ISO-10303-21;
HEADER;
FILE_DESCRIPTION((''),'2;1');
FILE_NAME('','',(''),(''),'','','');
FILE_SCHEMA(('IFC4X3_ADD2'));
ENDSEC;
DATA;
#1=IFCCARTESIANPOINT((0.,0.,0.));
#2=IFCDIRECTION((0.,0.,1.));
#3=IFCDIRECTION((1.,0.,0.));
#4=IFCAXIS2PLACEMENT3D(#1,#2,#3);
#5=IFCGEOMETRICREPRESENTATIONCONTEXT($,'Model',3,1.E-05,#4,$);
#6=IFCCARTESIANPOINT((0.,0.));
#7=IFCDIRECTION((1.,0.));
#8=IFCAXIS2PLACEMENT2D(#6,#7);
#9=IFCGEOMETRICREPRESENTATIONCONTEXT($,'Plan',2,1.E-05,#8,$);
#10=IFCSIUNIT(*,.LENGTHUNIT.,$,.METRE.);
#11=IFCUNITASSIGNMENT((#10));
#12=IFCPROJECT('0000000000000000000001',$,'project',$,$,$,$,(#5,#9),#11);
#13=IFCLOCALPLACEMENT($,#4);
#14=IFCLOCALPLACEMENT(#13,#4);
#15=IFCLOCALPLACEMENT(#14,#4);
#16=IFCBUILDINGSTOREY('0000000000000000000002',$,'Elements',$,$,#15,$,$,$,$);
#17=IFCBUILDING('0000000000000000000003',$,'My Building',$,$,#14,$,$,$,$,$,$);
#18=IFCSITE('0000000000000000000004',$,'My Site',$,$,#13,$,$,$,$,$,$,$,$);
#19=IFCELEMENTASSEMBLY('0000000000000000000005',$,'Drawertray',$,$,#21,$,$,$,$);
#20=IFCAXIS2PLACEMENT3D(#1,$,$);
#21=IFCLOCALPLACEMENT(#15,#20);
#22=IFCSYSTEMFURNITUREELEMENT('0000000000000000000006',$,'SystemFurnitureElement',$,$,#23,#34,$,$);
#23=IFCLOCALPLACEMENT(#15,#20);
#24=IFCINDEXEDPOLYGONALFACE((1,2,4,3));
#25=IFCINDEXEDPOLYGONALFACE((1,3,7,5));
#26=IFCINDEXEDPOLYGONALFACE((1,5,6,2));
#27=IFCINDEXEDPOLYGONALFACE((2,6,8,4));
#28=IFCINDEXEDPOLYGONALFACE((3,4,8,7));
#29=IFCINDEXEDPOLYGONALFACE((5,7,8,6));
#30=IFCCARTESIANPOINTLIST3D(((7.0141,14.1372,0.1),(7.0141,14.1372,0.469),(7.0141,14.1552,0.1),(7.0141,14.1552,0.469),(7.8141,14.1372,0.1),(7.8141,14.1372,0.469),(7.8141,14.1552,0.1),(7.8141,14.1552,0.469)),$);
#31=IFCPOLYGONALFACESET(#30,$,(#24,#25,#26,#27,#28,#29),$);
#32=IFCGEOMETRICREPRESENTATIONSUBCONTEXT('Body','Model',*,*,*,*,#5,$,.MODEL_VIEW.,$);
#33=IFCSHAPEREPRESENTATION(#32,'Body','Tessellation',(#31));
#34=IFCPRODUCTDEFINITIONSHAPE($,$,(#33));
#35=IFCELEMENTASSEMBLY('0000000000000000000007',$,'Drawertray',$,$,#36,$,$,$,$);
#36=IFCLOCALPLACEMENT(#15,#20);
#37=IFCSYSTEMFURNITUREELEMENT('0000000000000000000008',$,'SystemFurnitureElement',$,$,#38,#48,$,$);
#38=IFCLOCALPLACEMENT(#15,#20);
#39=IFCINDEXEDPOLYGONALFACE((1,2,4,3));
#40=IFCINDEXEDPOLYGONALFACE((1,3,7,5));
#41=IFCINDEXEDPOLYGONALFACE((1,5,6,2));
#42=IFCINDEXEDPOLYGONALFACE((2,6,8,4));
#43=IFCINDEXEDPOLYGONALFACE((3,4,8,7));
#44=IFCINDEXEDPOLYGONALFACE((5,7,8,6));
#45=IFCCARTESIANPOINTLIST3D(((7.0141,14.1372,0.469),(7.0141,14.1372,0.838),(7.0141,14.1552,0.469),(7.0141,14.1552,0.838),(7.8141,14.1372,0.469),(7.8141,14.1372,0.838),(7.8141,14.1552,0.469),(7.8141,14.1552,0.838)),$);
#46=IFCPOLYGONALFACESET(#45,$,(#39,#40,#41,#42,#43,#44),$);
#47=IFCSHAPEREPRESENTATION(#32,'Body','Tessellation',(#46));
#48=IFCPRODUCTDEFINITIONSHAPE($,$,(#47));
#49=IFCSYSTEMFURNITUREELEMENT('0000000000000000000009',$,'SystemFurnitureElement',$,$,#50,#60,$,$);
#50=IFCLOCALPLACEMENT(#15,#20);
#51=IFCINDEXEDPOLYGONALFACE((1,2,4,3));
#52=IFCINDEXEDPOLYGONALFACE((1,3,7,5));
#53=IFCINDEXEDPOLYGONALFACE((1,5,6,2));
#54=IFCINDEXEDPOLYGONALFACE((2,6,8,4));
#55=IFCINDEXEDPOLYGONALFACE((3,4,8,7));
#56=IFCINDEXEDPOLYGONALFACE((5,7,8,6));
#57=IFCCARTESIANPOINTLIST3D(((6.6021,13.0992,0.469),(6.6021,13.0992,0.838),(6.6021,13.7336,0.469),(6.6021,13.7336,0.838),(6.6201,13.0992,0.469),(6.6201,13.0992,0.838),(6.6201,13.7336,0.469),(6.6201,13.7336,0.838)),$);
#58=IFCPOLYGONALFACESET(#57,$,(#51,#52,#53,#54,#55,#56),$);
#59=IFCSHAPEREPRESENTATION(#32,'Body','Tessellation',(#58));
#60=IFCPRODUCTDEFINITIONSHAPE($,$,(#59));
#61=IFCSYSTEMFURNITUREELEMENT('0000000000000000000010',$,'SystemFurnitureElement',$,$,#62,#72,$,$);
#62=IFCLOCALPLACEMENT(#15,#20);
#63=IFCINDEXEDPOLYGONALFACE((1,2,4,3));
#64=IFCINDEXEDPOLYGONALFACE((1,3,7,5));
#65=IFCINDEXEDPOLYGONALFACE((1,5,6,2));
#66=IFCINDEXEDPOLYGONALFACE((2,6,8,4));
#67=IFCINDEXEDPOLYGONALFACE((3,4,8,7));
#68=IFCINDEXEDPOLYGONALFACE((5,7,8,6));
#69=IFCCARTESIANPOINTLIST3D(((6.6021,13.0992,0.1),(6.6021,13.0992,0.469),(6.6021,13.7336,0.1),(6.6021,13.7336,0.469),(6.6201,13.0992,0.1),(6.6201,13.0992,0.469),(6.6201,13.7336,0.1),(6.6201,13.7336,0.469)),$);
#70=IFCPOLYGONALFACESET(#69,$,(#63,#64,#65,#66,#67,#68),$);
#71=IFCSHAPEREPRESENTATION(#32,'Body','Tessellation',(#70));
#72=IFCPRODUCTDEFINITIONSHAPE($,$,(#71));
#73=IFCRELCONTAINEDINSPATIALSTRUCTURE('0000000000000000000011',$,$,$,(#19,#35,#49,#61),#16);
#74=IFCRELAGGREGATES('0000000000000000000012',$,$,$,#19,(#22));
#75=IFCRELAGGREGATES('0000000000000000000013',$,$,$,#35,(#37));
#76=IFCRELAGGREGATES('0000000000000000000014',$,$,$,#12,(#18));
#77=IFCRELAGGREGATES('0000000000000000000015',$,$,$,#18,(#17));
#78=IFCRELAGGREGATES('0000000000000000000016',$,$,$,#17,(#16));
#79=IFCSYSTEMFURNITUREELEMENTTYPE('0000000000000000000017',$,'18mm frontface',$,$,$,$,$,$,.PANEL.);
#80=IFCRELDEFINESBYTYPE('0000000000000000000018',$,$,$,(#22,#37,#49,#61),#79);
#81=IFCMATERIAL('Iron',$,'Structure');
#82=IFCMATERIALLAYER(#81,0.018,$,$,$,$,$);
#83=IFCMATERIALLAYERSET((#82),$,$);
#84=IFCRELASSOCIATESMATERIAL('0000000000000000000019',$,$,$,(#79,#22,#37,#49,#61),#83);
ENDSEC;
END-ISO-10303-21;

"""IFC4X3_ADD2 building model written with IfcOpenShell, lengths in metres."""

from ifc_helpers import new_model, si_unit, frame, origin_with_axes, origin_2d_with_axis, place, context, subcontext, project, spatial, line, indexed_curve, outline, extrude, material, layer, layer_set, layer_usage, type_object, element, aggregate, save


model = new_model("IFC4X3_ADD2")

# Units and contexts
model_context = context("Model", 3, precision=1e-05, world=origin_with_axes())
plan_context = context("Plan", 2, precision=1e-05, world=origin_2d_with_axis())
body_context = subcontext(model_context, "Body", "Model", "MODEL_VIEW")
ifc_project = project(units=[si_unit("LENGTHUNIT", "METRE")], contexts=[model_context, plan_context])

# Site, building, storey
site_placement = place(None, origin_with_axes())
site = spatial("IfcSite", under=ifc_project, at=site_placement, Name="My Site")
building_placement = place(site_placement, origin_with_axes())
building = spatial("IfcBuilding", under=site, at=building_placement, Name="My Building")
storey_placement = place(building_placement, origin_with_axes())
storey = spatial("IfcBuildingStorey", under=building, at=storey_placement, Name="Elements")

# Shared definitions
ifc_material_1 = material(Name="Iron", Category="Structure")
ifc_layer_1 = layer(ifc_material_1, 0.018)
ifc_layer_set_1 = layer_set([ifc_layer_1])
system_furniture_element_type_1 = type_object("IfcSystemFurnitureElementType", Name="18mm frontface", PredefinedType="PANEL", material=ifc_layer_set_1)

# Element assemblies, system furniture elements
assembly_1_placement = place(storey_placement, frame((7.0141, 14.1372, 0.1), z_axis=(0.0, 0.0, 1.0), x_axis=(-1.0, 0.0, 0.0)))
assembly_1 = element("IfcElementAssembly", 1, at=assembly_1_placement, inside=storey, Name="Drawertray")
ifc_layer_usage_1 = layer_usage(ifc_layer_set_1, "AXIS2", "POSITIVE", 0.0)
system_furniture_element_1_placement = place(assembly_1_placement, frame((0.0, 0.0, 0.0), z_axis=(0.0, 0.0, 1.0), x_axis=(-1.0, 0.0, 0.0)))
system_furniture_element_1 = element("IfcSystemFurnitureElement", 2, at=system_furniture_element_1_placement, type_object=system_furniture_element_type_1, material=ifc_layer_usage_1, Name="SystemFurnitureElement", context=body_context, shape_type="SweptSolid", body=[
    extrude(outline(indexed_curve([(0.0, 0.0), (0.0, 0.018), (0.8, 0.018), (0.8, 0.0)], segments=[line(1, 2, 3, 4, 1)])), origin_with_axes(), (0.0, 0.0, 1.0), 0.369),
])
aggregate(assembly_1, [system_furniture_element_1])
assembly_2_placement = place(storey_placement, frame((7.0141, 14.1372, 0.469), z_axis=(0.0, 0.0, 1.0), x_axis=(-1.0, 0.0, 0.0)))
assembly_2 = element("IfcElementAssembly", 3, at=assembly_2_placement, inside=storey, Name="Drawertray")
ifc_layer_usage_2 = layer_usage(ifc_layer_set_1, "AXIS2", "POSITIVE", 0.0)
system_furniture_element_2_placement = place(assembly_2_placement, frame((0.0, 0.0, 0.0), z_axis=(0.0, 0.0, 1.0), x_axis=(-1.0, 0.0, 0.0)))
system_furniture_element_2 = element("IfcSystemFurnitureElement", 4, at=system_furniture_element_2_placement, type_object=system_furniture_element_type_1, material=ifc_layer_usage_2, Name="SystemFurnitureElement", context=body_context, shape_type="SweptSolid", body=[
    extrude(outline(indexed_curve([(0.0, 0.0), (0.0, 0.018), (0.8, 0.018), (0.8, 0.0)], segments=[line(1, 2, 3, 4, 1)])), origin_with_axes(), (0.0, 0.0, 1.0), 0.369),
])
aggregate(assembly_2, [system_furniture_element_2])

# System furniture elements
ifc_layer_usage_3 = layer_usage(ifc_layer_set_1, "AXIS2", "POSITIVE", 0.0)
system_furniture_element_3_placement = place(storey_placement, frame((6.6021, 13.7336, 0.469), z_axis=(0.0, 0.0, 1.0), x_axis=(0.0, -1.0, 0.0)))
element("IfcSystemFurnitureElement", 5, at=system_furniture_element_3_placement, inside=storey, type_object=system_furniture_element_type_1, material=ifc_layer_usage_3, Name="SystemFurnitureElement", context=body_context, shape_type="SweptSolid", body=[
    extrude(outline(indexed_curve([(0.0, 0.0), (0.0, 0.018), (0.6345, 0.018), (0.6345, 0.0)], segments=[line(1, 2, 3, 4, 1)])), origin_with_axes(), (0.0, 0.0, 1.0), 0.369),
])
ifc_layer_usage_4 = layer_usage(ifc_layer_set_1, "AXIS2", "POSITIVE", 0.0)
system_furniture_element_4_placement = place(storey_placement, frame((6.6021, 13.7336, 0.1), z_axis=(0.0, 0.0, 1.0), x_axis=(0.0, -1.0, 0.0)))
element("IfcSystemFurnitureElement", 6, at=system_furniture_element_4_placement, inside=storey, type_object=system_furniture_element_type_1, material=ifc_layer_usage_4, Name="SystemFurnitureElement", context=body_context, shape_type="SweptSolid", body=[
    extrude(outline(indexed_curve([(0.0, 0.0), (0.0, 0.018), (0.6345, 0.018), (0.6345, 0.0)], segments=[line(1, 2, 3, 4, 1)])), origin_with_axes(), (0.0, 0.0, 1.0), 0.369),
])

save(model, "model.ifc")
